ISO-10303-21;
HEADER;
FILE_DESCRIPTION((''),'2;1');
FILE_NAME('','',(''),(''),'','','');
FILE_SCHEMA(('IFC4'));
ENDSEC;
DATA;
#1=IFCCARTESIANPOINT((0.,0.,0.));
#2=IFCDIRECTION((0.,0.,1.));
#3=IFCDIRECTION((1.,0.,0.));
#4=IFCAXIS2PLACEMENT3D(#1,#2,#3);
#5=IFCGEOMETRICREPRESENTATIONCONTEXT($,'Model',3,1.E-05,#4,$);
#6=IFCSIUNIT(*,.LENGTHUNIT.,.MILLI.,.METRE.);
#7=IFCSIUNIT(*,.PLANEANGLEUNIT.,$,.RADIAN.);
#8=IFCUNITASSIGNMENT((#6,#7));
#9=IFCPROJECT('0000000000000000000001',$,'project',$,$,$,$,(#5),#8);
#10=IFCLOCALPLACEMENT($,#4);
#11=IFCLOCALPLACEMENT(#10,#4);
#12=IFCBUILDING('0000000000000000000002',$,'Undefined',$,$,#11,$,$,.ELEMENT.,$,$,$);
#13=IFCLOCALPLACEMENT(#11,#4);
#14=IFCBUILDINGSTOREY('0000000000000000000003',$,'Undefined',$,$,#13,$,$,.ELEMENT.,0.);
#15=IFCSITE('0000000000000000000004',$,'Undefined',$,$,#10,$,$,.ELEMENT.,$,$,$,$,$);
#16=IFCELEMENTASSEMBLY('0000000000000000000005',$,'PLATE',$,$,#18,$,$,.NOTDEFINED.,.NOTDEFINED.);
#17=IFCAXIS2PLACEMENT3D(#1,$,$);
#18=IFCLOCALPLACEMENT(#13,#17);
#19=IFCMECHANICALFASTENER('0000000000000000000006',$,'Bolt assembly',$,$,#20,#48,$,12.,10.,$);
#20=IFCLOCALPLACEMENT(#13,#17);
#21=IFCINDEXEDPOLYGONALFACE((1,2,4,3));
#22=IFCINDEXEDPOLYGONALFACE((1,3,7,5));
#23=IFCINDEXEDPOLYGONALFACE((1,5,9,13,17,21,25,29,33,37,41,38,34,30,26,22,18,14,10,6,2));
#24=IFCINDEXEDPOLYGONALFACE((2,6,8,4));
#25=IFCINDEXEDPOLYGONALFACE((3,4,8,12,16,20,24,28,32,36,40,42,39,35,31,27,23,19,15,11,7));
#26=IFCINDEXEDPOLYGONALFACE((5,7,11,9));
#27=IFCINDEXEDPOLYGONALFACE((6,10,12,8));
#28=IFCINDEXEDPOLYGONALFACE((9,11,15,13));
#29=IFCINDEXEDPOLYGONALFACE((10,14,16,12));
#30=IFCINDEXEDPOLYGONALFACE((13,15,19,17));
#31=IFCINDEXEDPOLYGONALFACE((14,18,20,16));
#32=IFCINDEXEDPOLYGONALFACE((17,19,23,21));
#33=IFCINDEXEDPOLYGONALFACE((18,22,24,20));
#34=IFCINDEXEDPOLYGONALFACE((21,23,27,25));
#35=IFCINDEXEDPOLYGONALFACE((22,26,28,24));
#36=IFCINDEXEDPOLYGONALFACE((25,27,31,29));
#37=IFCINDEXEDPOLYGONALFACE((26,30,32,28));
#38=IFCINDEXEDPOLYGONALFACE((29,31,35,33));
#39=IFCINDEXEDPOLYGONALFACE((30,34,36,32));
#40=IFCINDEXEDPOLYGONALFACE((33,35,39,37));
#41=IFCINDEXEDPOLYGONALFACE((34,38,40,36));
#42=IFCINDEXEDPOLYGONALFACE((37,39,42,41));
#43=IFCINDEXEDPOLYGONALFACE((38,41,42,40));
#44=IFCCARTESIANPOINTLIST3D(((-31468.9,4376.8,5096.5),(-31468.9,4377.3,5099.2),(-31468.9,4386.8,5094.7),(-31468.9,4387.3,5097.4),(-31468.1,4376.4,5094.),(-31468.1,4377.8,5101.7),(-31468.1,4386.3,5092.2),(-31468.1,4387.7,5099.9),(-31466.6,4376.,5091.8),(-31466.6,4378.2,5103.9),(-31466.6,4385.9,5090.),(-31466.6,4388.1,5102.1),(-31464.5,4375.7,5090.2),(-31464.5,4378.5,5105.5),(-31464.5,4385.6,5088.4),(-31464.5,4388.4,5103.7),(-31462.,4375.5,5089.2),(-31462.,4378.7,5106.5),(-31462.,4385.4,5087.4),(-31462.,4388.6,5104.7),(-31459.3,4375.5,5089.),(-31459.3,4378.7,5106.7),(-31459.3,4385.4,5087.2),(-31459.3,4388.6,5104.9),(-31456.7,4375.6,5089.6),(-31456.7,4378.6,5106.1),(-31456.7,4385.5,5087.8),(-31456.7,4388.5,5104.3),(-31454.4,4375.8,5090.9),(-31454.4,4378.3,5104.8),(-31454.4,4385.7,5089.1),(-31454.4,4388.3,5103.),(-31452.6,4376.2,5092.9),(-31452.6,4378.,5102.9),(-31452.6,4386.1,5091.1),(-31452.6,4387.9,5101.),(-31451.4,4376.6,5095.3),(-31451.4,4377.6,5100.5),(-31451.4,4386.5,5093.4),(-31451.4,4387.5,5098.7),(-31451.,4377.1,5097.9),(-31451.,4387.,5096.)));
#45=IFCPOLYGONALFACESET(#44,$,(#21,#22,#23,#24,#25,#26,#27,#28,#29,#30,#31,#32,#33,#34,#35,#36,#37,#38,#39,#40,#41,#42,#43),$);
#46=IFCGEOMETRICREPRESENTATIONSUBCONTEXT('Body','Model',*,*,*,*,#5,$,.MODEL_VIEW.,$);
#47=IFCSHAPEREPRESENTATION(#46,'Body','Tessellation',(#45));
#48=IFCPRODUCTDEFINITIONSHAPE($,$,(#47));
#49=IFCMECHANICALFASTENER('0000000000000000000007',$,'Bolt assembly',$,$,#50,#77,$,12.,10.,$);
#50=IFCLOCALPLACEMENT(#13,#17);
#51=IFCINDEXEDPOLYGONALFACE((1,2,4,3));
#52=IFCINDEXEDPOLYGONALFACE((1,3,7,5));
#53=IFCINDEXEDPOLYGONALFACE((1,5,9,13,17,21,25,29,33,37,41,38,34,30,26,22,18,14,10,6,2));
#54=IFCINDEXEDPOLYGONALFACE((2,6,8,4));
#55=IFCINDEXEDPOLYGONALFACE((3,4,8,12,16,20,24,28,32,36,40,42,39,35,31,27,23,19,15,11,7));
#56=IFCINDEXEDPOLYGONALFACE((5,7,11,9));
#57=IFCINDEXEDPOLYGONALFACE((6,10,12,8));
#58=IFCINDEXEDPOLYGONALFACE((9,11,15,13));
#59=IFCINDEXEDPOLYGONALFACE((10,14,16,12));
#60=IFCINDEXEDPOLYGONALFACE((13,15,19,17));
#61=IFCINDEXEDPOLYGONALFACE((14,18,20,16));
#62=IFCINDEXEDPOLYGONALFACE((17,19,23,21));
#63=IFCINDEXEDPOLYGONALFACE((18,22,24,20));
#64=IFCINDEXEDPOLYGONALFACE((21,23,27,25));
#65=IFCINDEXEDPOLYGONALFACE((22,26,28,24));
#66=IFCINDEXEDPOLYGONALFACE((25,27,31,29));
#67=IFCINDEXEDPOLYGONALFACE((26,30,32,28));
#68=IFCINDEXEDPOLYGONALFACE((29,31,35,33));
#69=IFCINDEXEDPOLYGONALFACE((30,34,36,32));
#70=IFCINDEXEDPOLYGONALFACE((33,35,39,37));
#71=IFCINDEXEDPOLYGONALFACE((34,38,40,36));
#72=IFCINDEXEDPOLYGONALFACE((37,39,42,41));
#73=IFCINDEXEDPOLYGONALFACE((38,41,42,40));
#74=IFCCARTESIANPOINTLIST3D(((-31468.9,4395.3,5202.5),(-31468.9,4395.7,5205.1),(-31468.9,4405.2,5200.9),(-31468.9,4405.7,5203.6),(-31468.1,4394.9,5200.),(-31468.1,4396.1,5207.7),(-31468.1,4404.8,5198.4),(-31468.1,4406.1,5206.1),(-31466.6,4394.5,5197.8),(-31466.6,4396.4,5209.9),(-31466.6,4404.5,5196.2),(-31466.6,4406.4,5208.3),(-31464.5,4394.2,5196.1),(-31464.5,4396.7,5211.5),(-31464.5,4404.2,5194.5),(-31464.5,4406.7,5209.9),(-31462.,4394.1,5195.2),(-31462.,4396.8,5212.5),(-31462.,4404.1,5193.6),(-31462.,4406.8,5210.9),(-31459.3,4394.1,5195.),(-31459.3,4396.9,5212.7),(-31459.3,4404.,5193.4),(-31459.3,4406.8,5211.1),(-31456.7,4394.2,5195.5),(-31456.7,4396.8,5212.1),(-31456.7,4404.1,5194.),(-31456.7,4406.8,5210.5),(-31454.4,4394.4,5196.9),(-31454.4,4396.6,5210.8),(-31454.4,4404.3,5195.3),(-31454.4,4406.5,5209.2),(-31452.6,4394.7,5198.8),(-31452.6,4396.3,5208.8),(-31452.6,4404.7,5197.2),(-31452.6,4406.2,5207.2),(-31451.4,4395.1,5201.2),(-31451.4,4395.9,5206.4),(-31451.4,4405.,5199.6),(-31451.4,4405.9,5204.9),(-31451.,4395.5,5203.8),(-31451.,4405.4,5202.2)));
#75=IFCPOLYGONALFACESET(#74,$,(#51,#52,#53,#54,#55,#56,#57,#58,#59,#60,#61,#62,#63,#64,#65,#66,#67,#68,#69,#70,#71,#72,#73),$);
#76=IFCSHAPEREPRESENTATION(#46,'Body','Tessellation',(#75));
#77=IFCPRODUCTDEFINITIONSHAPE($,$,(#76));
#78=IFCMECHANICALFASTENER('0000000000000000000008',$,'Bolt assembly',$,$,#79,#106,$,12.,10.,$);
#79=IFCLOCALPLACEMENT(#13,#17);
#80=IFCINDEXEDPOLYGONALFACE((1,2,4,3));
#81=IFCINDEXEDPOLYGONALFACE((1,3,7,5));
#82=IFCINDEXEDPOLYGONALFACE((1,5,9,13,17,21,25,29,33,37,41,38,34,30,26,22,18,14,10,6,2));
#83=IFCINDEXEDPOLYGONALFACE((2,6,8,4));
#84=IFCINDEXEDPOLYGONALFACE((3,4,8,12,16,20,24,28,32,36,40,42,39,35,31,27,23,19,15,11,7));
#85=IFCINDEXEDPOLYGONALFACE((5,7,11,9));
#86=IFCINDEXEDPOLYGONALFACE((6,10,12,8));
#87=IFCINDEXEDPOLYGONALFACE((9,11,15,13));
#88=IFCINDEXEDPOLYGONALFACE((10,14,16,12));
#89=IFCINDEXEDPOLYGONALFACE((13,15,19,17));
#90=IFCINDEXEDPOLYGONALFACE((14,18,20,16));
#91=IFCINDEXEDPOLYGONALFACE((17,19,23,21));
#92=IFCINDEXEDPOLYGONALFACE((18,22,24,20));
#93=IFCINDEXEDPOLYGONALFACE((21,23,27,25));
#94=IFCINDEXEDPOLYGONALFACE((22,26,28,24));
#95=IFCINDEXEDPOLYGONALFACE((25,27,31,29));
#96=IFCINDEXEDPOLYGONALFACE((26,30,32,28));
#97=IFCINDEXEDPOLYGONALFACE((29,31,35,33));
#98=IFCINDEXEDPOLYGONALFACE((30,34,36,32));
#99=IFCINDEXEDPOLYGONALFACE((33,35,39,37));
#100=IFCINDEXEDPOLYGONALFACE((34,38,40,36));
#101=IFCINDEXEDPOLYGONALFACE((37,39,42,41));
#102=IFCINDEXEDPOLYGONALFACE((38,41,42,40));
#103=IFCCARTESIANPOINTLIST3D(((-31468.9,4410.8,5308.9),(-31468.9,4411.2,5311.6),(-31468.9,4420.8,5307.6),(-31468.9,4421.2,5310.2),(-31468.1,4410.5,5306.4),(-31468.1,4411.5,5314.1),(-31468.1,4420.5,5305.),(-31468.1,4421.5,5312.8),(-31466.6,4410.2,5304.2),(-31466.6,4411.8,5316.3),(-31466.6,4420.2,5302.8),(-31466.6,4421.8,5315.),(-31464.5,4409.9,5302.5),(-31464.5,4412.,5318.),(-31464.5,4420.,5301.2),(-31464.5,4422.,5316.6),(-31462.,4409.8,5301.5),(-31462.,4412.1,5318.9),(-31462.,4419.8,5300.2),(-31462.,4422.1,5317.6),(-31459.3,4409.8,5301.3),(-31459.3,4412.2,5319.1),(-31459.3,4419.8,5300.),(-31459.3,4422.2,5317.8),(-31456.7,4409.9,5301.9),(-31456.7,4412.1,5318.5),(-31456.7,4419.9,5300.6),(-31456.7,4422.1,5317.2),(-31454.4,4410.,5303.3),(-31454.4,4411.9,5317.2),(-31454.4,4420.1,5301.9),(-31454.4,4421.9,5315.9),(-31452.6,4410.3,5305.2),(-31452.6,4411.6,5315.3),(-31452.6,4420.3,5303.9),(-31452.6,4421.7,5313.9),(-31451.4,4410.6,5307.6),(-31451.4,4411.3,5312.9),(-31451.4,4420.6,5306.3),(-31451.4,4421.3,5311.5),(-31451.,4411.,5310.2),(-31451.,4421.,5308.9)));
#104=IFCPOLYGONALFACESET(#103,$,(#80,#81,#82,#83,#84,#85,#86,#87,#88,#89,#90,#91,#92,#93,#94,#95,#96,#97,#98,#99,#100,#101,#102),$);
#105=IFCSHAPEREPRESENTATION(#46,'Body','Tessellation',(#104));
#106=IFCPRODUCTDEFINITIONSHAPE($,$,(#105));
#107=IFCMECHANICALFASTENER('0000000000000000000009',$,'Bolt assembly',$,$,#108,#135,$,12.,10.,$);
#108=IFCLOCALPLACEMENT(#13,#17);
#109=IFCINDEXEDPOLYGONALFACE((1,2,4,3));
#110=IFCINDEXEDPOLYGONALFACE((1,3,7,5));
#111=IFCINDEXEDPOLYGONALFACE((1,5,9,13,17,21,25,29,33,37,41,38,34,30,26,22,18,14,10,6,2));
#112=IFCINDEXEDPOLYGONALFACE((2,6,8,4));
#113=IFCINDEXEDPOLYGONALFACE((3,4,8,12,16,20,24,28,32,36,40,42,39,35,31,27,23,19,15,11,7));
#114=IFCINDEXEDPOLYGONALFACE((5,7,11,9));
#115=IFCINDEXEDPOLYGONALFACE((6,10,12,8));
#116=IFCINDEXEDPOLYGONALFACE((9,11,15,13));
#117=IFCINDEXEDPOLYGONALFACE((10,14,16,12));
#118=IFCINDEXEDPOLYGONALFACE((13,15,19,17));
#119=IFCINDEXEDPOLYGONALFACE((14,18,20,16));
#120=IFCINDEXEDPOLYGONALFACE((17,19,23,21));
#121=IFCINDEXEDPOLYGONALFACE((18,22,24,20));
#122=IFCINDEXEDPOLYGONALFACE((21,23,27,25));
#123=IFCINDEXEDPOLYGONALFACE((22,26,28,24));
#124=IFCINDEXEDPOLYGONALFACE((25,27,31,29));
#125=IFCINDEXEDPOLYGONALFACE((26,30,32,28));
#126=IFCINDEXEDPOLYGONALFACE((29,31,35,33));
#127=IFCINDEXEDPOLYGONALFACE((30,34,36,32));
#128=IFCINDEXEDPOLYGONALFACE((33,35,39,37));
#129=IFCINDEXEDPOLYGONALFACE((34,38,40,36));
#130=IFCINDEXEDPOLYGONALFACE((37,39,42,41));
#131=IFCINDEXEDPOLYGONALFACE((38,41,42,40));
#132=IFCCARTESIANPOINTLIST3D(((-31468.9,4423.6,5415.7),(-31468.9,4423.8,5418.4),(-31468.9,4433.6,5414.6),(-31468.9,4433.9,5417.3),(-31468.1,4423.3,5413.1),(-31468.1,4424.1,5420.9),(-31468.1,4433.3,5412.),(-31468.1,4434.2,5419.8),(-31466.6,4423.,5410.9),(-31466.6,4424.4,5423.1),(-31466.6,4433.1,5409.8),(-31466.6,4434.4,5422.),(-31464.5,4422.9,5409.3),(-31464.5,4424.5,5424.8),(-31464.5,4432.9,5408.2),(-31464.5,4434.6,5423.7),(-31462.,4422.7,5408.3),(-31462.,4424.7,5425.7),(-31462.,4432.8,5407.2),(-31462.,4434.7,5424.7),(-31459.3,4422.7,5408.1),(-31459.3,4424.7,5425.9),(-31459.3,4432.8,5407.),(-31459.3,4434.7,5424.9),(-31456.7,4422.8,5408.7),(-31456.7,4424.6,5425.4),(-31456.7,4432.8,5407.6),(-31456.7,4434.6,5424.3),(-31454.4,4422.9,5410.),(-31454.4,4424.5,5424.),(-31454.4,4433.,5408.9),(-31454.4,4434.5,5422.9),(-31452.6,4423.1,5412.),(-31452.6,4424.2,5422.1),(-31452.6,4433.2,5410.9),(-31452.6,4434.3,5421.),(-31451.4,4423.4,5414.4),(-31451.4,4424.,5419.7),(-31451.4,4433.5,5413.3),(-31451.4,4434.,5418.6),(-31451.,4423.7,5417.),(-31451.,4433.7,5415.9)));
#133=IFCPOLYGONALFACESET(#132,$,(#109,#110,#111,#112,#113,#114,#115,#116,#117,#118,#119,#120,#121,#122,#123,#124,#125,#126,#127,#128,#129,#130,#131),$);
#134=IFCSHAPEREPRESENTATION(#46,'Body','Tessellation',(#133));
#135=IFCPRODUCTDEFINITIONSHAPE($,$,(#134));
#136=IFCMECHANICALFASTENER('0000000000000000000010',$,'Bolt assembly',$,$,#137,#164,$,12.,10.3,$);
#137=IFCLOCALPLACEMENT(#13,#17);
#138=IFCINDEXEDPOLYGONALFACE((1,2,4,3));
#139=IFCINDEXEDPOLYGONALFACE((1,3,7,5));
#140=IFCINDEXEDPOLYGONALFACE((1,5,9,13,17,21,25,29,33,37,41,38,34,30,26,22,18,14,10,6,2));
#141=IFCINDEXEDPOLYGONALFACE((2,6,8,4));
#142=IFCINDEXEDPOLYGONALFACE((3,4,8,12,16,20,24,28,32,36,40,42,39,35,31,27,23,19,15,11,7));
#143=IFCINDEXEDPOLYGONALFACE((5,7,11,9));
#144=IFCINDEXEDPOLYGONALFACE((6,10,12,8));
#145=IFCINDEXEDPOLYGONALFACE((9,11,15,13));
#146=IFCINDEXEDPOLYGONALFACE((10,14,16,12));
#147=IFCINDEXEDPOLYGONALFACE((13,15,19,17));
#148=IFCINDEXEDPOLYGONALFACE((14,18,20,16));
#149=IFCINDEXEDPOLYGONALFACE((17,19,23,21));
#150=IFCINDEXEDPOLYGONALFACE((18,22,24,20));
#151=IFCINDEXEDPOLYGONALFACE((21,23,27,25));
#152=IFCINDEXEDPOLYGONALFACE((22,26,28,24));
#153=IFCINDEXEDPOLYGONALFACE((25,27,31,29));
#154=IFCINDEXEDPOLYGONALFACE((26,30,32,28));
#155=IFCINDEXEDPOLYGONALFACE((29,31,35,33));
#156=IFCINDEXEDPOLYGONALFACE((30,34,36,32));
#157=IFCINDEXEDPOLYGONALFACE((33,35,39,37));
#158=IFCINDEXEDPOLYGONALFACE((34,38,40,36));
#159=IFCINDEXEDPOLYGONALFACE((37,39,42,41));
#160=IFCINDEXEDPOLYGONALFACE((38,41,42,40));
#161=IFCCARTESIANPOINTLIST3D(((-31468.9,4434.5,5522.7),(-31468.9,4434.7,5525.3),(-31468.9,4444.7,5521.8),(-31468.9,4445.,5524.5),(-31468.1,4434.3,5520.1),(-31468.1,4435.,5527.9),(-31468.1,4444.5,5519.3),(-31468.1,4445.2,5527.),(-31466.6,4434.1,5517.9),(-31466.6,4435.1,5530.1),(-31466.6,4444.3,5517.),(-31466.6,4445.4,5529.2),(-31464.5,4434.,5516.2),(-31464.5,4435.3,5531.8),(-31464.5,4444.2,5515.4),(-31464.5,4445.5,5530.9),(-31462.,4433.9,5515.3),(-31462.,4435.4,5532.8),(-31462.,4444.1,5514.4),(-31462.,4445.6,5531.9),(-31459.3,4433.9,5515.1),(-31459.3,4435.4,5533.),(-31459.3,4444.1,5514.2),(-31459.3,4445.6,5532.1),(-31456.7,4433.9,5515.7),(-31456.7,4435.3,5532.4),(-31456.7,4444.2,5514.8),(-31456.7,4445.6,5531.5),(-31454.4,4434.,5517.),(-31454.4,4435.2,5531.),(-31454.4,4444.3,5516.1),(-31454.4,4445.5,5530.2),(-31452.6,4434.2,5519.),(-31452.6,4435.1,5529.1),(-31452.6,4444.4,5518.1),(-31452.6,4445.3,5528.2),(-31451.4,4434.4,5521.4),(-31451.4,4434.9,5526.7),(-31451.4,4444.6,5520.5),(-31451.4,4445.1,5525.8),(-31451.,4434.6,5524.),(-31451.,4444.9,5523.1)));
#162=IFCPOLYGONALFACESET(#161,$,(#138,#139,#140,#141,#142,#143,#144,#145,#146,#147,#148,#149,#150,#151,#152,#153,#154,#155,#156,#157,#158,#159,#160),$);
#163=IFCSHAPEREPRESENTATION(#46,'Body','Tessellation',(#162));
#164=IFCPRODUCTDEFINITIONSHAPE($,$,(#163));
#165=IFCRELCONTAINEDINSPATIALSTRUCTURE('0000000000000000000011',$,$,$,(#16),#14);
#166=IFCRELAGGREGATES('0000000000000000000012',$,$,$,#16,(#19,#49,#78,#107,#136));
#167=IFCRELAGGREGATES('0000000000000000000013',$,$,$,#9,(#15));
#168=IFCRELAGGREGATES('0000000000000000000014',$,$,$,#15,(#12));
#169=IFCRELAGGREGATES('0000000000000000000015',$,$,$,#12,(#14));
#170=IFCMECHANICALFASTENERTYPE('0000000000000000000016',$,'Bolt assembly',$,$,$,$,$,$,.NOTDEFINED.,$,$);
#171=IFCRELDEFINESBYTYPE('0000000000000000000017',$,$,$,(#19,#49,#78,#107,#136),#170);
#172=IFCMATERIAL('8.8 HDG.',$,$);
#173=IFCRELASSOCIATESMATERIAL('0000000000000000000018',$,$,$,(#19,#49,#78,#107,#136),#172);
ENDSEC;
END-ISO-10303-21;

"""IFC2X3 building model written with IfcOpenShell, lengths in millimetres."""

from ifc_helpers import new_model, si_unit, frame, origin_with_axes, origin_2d_with_axis, place, context, subcontext, project, spatial, circle, extrude, source, transform, mapped, material, type_object, element, aggregate, save


model = new_model("IFC2X3")

# Units and contexts
model_context = context("Model", 3, precision=1e-05, world=origin_with_axes())
body_context = subcontext(model_context, "Body", "Model", "MODEL_VIEW")
ifc_project = project(units=[si_unit("LENGTHUNIT", "METRE", prefix="MILLI"), si_unit("PLANEANGLEUNIT", "RADIAN")], contexts=[model_context])

# Site, building, storey
site_placement = place(None, origin_with_axes())
site = spatial("IfcSite", under=ifc_project, at=site_placement, Name="Undefined", CompositionType="ELEMENT")
building_placement = place(site_placement, origin_with_axes())
building = spatial("IfcBuilding", under=site, at=building_placement, Name="Undefined", CompositionType="ELEMENT")
storey_placement = place(building_placement, origin_with_axes())
storey = spatial("IfcBuildingStorey", under=building, at=storey_placement, Name="Undefined", CompositionType="ELEMENT", Elevation=0.0)

# Element assembly, mechanical fasteners
assembly_placement = place(storey_placement, origin_with_axes())
assembly = element("IfcElementAssembly", 1, at=assembly_placement, inside=storey, Name="PLATE", AssemblyPlace="NOTDEFINED", PredefinedType="NOTDEFINED")
ifc_material_1 = material(Name="8.8 HDG.")
mechanical_fastener_type = type_object("IfcMechanicalFastenerType", Name="Bolt assembly")
shared_shape_1 = source(origin_with_axes(), body_context, "Body", "SweptSolid", [
    extrude(circle(Radius=9.0, at=origin_2d_with_axis()), frame((0.0, 0.9, 0.0), z_axis=(0.0, 1.0, 0.0), x_axis=(1.0, 0.0, 0.0)), (0.0, 0.0, 1.0), 10.1),
])
mechanical_fastener_1_placement = place(assembly_placement, frame((-31460.0, 4387.9, 5095.9), z_axis=(0.000001, -0.180255, -0.98362), x_axis=(1.0, 0.000001, 0.000001)))
mechanical_fastener_1 = element("IfcMechanicalFastener", 2, at=mechanical_fastener_1_placement, type_object=mechanical_fastener_type, material=ifc_material_1, Name="Bolt assembly", NominalDiameter=12.0, NominalLength=10.0, context=body_context, shape_type="MappedRepresentation", body=[
    mapped(shared_shape_1, transform((0.0, 0.0, 0.0))),
])
shared_shape_2 = source(origin_with_axes(), body_context, "Body", "SweptSolid", [
    extrude(circle(Radius=9.0, at=origin_2d_with_axis()), frame((0.0, 0.6, 0.0), z_axis=(0.0, 1.0, 0.0), x_axis=(1.0, 0.0, 0.0)), (0.0, 0.0, 1.0), 10.1),
])
mechanical_fastener_2_placement = place(assembly_placement, frame((-31460.0, 4406.0, 5202.2), z_axis=(0.000001, -0.156435, -0.987688), x_axis=(1.0, 0.000001, 0.000001)))
mechanical_fastener_2 = element("IfcMechanicalFastener", 3, at=mechanical_fastener_2_placement, type_object=mechanical_fastener_type, material=ifc_material_1, Name="Bolt assembly", NominalDiameter=12.0, NominalLength=10.0, context=body_context, shape_type="MappedRepresentation", body=[
    mapped(shared_shape_2, transform((0.0, 0.0, 0.0))),
])
shared_shape_3 = source(origin_with_axes(), body_context, "Body", "SweptSolid", [
    extrude(circle(Radius=9.0, at=origin_2d_with_axis()), frame((0.0, 0.6, 0.0), z_axis=(0.0, 1.0, 0.0), x_axis=(1.0, 0.0, 0.0)), (0.0, 0.0, 1.0), 10.1),
])
mechanical_fastener_3_placement = place(assembly_placement, frame((-31460.0, 4421.6, 5308.8), z_axis=(0.000001, -0.132523, -0.99118), x_axis=(1.0, 0.000001, 0.000001)))
mechanical_fastener_3 = element("IfcMechanicalFastener", 4, at=mechanical_fastener_3_placement, type_object=mechanical_fastener_type, material=ifc_material_1, Name="Bolt assembly", NominalDiameter=12.0, NominalLength=10.0, context=body_context, shape_type="MappedRepresentation", body=[
    mapped(shared_shape_3, transform((0.0, 0.0, 0.0))),
])
shared_shape_4 = source(origin_with_axes(), body_context, "Body", "SweptSolid", [
    extrude(circle(Radius=9.0, at=origin_2d_with_axis()), frame((0.0, 0.9, 0.0), z_axis=(0.0, 1.0, 0.0), x_axis=(1.0, 0.0, 0.0)), (0.0, 0.0, 1.0), 10.1),
])
mechanical_fastener_4_placement = place(assembly_placement, frame((-31460.0, 4434.6, 5415.8), z_axis=(0.000001, -0.108533, -0.994093), x_axis=(1.0, 0.000001, 0.000001)))
mechanical_fastener_4 = element("IfcMechanicalFastener", 5, at=mechanical_fastener_4_placement, type_object=mechanical_fastener_type, material=ifc_material_1, Name="Bolt assembly", NominalDiameter=12.0, NominalLength=10.0, context=body_context, shape_type="MappedRepresentation", body=[
    mapped(shared_shape_4, transform((0.0, 0.0, 0.0))),
])
shared_shape_5 = source(origin_with_axes(), body_context, "Body", "SweptSolid", [
    extrude(circle(Radius=9.0, at=origin_2d_with_axis()), frame((0.0, 0.1, 0.0), z_axis=(0.0, 1.0, 0.0), x_axis=(1.0, 0.0, 0.0)), (0.0, 0.0, 1.0), 10.3),
])
mechanical_fastener_5_placement = place(assembly_placement, frame((-31460.0, 4445.0, 5523.1), z_axis=(0.000001, -0.084481, -0.996425), x_axis=(1.0, 0.000001, 0.000001)))
mechanical_fastener_5 = element("IfcMechanicalFastener", 6, at=mechanical_fastener_5_placement, type_object=mechanical_fastener_type, material=ifc_material_1, Name="Bolt assembly", NominalDiameter=12.0, NominalLength=10.3, context=body_context, shape_type="MappedRepresentation", body=[
    mapped(shared_shape_5, transform((0.0, 0.0, 0.0))),
])
aggregate(assembly, [mechanical_fastener_1, mechanical_fastener_2, mechanical_fastener_3, mechanical_fastener_4, mechanical_fastener_5])

save(model, "model.ifc")
